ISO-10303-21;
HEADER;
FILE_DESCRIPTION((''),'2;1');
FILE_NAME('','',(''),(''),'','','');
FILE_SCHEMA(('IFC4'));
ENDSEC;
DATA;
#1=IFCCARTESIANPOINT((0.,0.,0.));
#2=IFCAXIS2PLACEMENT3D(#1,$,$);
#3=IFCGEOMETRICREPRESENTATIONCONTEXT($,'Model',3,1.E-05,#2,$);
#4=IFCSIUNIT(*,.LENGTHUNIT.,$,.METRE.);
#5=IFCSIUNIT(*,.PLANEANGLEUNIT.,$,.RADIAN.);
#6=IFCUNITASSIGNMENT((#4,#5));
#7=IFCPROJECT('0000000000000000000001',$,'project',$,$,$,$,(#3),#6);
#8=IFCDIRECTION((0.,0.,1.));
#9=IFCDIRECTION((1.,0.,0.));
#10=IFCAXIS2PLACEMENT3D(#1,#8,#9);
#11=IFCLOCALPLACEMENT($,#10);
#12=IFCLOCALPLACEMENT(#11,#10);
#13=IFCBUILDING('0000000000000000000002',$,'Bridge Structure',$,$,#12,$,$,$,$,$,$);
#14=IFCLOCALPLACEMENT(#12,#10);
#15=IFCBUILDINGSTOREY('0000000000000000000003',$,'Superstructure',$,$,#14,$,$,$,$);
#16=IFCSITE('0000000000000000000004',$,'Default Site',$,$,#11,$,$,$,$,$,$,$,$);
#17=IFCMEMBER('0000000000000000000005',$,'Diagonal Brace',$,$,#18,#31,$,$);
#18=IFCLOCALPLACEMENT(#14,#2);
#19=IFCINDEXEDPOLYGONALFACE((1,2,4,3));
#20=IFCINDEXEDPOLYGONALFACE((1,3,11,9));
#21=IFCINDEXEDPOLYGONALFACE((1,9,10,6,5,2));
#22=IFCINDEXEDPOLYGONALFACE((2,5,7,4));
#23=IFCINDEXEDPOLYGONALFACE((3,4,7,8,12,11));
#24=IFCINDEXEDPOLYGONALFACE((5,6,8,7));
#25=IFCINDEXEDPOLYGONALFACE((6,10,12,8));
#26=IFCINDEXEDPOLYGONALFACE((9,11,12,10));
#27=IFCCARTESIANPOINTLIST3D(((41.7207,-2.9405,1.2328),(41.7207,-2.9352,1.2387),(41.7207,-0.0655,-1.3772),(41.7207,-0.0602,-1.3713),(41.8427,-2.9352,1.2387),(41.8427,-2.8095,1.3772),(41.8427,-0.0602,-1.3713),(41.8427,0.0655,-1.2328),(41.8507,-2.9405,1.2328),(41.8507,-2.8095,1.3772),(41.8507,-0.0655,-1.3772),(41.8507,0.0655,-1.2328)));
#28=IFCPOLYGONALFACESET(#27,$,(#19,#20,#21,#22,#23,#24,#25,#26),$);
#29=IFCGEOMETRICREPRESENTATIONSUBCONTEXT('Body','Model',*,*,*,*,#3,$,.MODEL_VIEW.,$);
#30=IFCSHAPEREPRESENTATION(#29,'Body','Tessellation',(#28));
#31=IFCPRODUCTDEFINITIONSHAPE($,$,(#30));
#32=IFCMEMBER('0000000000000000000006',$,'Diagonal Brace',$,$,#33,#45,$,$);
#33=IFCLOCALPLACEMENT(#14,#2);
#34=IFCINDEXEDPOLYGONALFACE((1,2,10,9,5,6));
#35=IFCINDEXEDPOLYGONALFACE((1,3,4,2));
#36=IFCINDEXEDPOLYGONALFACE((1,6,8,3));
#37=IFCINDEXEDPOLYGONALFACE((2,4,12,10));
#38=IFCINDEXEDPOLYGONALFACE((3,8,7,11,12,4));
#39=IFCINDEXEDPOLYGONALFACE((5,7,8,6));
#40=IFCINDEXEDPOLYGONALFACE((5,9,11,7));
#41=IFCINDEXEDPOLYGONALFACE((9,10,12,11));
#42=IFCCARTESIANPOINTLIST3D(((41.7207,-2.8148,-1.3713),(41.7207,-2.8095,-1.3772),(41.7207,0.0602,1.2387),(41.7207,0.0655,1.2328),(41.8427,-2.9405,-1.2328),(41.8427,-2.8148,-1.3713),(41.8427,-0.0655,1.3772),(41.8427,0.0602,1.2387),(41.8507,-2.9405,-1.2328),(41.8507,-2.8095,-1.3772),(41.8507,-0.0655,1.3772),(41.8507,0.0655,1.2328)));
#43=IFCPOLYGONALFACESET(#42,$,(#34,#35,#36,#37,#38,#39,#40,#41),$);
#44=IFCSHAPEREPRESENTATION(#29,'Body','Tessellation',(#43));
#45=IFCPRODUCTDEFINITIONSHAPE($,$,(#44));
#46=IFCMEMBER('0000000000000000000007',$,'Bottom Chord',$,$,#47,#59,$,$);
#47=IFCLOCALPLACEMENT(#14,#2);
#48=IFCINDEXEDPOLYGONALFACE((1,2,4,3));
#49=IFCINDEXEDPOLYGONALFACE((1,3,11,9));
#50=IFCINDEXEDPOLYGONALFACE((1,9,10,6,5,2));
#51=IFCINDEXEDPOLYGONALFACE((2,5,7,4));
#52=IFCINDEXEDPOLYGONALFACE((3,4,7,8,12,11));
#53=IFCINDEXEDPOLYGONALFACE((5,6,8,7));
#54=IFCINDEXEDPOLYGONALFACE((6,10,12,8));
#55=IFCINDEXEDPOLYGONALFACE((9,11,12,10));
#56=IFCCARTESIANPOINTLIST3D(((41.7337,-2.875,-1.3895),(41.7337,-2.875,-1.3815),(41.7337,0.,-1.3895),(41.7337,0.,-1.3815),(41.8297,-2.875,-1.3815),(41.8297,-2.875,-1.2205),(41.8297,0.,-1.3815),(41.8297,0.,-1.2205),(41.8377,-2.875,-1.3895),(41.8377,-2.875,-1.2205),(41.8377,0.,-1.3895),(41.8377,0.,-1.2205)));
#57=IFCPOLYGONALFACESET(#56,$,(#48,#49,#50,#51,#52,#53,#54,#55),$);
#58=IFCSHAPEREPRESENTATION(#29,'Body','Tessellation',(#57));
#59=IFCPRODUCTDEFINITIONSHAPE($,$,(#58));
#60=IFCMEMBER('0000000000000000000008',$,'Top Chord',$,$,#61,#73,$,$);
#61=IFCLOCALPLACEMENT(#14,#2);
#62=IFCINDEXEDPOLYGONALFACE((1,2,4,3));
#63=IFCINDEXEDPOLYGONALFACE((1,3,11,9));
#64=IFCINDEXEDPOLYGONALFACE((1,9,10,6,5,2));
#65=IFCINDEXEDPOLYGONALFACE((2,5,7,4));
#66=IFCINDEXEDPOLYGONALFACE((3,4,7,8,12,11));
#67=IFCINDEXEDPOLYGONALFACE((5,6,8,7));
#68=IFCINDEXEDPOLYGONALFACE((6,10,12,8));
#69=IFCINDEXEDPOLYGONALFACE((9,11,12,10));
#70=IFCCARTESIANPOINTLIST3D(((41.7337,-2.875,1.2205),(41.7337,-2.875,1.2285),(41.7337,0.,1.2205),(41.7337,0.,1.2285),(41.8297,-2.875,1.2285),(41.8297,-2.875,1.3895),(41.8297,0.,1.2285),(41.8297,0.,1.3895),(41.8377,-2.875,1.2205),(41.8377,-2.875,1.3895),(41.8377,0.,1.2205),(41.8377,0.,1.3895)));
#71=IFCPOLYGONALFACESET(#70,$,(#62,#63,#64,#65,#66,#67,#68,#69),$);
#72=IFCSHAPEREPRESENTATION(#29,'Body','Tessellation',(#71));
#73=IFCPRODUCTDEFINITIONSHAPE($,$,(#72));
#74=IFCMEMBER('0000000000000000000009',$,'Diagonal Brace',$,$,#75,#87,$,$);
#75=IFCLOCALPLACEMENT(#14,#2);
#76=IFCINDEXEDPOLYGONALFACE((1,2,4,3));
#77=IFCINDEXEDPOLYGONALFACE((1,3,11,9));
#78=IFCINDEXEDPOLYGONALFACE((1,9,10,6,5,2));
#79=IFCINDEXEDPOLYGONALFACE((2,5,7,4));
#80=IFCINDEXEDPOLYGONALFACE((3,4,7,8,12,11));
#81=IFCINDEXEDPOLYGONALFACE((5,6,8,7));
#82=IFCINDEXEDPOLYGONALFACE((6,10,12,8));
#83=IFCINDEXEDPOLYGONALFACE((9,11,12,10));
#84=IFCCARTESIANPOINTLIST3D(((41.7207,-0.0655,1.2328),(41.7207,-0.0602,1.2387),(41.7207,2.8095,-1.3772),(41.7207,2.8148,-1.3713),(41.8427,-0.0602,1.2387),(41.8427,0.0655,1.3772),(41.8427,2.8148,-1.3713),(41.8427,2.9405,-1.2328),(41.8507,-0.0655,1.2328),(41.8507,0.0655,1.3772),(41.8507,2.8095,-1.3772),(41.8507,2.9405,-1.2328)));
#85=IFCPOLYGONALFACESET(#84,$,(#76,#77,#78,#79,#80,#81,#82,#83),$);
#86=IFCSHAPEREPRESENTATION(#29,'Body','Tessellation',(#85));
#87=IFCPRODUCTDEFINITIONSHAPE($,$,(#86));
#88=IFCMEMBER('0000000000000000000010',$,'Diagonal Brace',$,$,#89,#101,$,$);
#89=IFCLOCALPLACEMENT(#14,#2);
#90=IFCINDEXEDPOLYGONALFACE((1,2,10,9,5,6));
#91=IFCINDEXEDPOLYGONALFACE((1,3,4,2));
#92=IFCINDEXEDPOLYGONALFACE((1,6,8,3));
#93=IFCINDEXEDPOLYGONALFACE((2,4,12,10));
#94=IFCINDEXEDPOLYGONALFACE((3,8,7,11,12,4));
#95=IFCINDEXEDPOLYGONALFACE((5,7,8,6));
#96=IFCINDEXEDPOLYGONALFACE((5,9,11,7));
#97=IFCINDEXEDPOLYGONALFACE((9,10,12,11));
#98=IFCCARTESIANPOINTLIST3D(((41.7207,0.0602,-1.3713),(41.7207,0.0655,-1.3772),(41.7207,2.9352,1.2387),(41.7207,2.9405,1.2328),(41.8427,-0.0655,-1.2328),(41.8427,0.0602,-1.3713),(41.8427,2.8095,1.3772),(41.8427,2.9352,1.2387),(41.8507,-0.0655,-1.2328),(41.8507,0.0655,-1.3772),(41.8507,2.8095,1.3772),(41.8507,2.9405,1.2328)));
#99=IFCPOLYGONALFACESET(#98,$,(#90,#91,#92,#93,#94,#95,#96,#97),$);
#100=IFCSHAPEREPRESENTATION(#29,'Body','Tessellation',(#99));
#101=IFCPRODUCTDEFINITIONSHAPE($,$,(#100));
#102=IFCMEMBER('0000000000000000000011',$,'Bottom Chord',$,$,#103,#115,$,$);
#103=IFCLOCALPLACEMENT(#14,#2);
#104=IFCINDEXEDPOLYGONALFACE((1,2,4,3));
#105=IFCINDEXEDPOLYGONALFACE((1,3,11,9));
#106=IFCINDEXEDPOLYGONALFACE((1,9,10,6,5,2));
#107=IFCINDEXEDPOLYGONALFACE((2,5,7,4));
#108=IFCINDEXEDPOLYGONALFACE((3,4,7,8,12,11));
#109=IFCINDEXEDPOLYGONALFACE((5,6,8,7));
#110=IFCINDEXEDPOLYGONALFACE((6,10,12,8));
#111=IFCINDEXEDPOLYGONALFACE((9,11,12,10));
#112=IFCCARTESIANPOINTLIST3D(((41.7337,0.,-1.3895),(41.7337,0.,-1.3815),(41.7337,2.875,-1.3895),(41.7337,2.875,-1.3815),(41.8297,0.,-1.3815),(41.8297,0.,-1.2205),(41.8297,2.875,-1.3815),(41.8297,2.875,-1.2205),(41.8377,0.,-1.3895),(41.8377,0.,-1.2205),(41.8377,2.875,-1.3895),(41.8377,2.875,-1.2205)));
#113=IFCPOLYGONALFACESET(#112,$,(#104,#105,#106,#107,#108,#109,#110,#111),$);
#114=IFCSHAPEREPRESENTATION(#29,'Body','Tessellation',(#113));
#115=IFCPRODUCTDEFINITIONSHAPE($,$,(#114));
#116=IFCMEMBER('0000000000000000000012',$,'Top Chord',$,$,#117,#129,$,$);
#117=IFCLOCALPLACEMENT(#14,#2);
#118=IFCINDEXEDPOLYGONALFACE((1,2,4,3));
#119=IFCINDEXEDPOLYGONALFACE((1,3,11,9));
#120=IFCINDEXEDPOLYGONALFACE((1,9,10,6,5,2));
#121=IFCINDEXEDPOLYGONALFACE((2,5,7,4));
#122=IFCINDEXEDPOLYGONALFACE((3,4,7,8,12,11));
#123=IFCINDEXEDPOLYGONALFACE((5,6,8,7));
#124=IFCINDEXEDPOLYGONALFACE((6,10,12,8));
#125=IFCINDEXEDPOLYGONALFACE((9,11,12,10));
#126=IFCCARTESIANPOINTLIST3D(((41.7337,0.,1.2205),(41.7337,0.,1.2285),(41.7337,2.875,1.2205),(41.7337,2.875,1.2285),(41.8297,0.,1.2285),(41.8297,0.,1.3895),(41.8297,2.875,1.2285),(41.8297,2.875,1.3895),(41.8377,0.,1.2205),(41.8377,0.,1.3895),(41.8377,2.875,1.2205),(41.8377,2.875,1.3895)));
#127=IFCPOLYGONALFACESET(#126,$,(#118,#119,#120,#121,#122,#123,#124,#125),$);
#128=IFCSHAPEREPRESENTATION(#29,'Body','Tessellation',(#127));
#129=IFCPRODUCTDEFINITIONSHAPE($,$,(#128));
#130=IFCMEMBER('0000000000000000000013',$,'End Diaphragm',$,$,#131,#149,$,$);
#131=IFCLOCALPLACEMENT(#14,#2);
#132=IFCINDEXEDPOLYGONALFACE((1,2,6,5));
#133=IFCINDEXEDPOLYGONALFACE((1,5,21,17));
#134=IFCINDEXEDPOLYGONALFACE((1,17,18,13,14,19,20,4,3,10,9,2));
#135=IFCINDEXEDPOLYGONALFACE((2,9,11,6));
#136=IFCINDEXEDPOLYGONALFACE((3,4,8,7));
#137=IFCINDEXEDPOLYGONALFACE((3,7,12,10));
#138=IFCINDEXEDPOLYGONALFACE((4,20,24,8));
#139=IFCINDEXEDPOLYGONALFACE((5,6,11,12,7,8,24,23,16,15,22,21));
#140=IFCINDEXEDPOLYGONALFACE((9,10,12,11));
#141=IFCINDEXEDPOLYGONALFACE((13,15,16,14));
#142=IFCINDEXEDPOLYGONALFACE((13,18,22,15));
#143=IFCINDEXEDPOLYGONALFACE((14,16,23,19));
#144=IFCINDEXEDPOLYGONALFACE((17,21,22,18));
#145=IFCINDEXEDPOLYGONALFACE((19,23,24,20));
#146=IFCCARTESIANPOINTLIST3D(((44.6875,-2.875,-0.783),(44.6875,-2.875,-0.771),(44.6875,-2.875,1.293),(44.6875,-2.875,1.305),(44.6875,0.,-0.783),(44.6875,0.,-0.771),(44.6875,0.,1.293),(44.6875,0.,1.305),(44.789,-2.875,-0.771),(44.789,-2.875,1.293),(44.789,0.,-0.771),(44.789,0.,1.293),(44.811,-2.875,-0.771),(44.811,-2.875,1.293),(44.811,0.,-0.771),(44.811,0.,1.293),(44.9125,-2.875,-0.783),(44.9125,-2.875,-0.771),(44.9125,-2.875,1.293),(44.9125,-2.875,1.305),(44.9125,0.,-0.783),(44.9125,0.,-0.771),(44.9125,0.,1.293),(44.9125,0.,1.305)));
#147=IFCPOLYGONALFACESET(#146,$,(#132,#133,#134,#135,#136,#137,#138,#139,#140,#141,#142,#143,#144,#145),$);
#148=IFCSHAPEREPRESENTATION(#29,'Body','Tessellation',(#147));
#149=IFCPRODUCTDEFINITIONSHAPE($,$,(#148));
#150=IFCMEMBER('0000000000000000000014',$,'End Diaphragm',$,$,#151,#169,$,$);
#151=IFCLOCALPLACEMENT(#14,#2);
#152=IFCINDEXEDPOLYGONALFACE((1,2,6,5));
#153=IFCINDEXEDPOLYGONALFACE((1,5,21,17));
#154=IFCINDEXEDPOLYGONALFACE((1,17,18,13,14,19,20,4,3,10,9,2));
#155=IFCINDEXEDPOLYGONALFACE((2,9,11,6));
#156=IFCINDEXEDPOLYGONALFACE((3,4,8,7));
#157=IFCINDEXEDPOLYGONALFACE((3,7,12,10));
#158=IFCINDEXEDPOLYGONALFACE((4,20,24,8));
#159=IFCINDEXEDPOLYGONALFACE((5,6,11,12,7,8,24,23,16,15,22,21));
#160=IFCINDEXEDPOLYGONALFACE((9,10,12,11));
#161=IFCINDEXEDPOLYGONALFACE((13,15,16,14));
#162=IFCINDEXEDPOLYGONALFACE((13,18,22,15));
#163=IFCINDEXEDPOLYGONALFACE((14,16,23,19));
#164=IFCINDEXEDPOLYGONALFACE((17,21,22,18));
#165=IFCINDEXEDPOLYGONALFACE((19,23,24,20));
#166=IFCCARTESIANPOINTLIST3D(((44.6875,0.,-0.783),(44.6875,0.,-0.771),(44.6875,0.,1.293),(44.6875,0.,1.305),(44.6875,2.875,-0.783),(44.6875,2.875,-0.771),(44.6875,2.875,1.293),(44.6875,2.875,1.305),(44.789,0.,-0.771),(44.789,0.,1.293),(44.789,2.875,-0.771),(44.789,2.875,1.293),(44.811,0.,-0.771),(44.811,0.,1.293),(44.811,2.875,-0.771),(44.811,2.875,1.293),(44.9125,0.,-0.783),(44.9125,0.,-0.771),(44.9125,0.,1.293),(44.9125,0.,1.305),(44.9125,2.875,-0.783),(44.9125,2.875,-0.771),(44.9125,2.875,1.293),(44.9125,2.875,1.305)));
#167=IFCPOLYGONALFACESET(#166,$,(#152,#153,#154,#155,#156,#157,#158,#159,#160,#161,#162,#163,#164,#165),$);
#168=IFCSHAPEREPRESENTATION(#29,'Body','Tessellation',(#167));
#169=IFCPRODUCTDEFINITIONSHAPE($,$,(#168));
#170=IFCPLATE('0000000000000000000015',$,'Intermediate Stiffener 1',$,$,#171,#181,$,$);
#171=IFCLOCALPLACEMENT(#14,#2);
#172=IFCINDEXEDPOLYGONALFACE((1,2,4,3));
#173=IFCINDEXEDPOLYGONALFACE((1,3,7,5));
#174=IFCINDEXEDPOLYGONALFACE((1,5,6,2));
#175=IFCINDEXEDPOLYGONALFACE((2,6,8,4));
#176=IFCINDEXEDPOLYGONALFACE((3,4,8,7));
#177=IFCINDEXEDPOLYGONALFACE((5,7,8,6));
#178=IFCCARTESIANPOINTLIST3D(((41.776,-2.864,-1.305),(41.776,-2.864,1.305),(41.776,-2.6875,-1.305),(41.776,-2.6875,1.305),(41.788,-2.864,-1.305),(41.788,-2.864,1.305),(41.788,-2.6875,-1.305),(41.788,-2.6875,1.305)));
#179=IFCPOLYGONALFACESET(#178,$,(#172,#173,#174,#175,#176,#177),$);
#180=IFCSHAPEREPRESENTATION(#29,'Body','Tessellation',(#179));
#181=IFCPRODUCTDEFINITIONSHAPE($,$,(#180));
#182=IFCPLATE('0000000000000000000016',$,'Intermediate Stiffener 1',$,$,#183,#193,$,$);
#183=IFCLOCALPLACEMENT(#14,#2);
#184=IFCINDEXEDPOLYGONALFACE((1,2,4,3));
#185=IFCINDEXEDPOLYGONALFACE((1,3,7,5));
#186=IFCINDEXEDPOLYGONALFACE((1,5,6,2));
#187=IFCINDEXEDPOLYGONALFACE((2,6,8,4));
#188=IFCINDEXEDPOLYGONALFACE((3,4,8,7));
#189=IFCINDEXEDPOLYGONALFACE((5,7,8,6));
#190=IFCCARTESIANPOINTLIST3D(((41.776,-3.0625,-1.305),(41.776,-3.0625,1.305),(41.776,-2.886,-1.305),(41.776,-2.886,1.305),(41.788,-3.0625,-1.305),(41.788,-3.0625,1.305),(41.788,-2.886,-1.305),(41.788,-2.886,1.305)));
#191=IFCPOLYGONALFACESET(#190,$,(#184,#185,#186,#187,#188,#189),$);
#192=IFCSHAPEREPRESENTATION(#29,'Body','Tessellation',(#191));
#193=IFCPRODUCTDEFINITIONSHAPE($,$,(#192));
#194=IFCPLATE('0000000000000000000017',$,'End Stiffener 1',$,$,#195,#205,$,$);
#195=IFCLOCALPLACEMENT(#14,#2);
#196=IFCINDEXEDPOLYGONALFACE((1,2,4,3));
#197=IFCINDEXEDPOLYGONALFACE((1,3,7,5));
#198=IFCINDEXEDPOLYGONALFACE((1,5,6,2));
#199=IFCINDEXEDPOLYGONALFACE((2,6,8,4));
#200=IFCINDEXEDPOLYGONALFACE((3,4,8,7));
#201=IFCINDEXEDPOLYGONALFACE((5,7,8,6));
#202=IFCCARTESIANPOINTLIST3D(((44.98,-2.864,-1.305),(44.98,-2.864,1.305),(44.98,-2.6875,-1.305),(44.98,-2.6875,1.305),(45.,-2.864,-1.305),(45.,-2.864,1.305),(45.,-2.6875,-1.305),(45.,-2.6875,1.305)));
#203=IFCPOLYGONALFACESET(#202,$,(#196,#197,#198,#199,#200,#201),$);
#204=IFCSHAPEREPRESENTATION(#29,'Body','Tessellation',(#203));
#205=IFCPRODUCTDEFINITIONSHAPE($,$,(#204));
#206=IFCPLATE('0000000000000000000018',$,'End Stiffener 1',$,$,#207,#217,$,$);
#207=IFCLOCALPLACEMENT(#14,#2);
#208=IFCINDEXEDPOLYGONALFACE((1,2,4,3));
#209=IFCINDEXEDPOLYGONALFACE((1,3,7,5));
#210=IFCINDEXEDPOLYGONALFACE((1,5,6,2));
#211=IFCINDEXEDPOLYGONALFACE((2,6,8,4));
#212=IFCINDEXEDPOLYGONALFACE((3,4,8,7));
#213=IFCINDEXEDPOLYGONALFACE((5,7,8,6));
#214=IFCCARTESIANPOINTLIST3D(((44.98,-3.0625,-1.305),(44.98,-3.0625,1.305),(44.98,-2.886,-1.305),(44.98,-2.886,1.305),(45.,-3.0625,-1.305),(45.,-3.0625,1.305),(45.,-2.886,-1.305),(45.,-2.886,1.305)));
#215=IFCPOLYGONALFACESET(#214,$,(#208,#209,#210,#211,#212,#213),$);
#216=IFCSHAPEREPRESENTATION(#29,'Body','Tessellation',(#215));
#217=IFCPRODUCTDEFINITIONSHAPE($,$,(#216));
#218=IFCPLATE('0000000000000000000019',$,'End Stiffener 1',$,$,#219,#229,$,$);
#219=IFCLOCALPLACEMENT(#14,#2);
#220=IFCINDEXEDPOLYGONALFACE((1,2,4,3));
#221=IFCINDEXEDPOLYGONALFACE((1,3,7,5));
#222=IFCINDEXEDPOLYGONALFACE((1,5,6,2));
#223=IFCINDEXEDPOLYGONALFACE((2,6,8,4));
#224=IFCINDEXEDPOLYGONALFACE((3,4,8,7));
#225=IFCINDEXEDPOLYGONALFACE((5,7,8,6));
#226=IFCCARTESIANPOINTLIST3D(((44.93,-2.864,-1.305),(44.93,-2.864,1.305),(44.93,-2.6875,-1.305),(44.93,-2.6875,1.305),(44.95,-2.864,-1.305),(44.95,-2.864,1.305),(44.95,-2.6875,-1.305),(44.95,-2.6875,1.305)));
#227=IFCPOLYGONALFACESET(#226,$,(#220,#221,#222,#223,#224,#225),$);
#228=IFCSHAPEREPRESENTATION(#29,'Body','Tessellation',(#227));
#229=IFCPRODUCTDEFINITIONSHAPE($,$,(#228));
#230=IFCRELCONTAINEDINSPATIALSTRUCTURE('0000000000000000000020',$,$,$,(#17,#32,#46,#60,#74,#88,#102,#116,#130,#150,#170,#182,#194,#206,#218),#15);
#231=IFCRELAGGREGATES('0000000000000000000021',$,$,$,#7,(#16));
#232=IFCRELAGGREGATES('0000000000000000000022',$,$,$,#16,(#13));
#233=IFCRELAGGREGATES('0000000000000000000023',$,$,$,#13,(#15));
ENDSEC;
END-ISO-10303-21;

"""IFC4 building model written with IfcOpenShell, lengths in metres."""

from ifc_helpers import new_model, si_unit, frame, origin, origin_with_axes, origin_2d_with_axis, place, context, subcontext, project, spatial, rectangle, i_section, l_section, extrude, element, save


model = new_model("IFC4")

# Units and contexts
model_context = context("Model", 3, precision=1e-05, world=origin())
body_context = subcontext(model_context, "Body", "Model", "MODEL_VIEW")
ifc_project = project(units=[si_unit("LENGTHUNIT", "METRE"), si_unit("PLANEANGLEUNIT", "RADIAN")], contexts=[model_context])

# Site, building, storey
site_placement = place(None, origin_with_axes())
site = spatial("IfcSite", under=ifc_project, at=site_placement, Name="Default Site")
building_placement = place(site_placement, origin_with_axes())
building = spatial("IfcBuilding", under=site, at=building_placement, Name="Bridge Structure")
storey_placement = place(building_placement, origin_with_axes())
storey = spatial("IfcBuildingStorey", under=building, at=storey_placement, Name="Superstructure")

# Members
for number, where, z_axis, x_axis, name in (
    (1, (41.7857, -2.875, 1.305), (0.0, 0.740406, -0.67216), (-1.0, 0.0, 0.0), "Diagonal Brace"),
    (2, (41.7857, -2.875, -1.305), (0.0, 0.740406, 0.67216), (-1.0, 0.0, 0.0), "Diagonal Brace"),
):
    element("IfcMember", number, at=place(storey_placement, frame(where, z_axis=z_axis, x_axis=x_axis)), inside=storey, Name=name, context=body_context, shape_type="SweptSolid", body=[
        extrude(l_section(Depth=0.195, Width=0.13, Thickness=0.008, at=origin_2d_with_axis()), origin_with_axes(), (0.0, 0.0, 1.0), 3.883),
    ])
for number, where, z_axis, x_axis, name in (
    (3, (41.7857, -2.875, -1.305), (0.0, 1.0, 0.0), (-1.0, 0.0, 0.0), "Bottom Chord"),
    (4, (41.7857, -2.875, 1.305), (0.0, 1.0, 0.0), (-1.0, 0.0, 0.0), "Top Chord"),
):
    element("IfcMember", number, at=place(storey_placement, frame(where, z_axis=z_axis, x_axis=x_axis)), inside=storey, Name=name, context=body_context, shape_type="SweptSolid", body=[
        extrude(l_section(Depth=0.169, Width=0.104, Thickness=0.008, at=origin_2d_with_axis()), origin_with_axes(), (0.0, 0.0, 1.0), 2.875),
    ])
for number, where, z_axis, x_axis, name in (
    (5, (41.7857, 0.0, 1.305), (0.0, 0.740406, -0.67216), (-1.0, 0.0, 0.0), "Diagonal Brace"),
    (6, (41.7857, 0.0, -1.305), (0.0, 0.740406, 0.67216), (-1.0, 0.0, 0.0), "Diagonal Brace"),
):
    element("IfcMember", number, at=place(storey_placement, frame(where, z_axis=z_axis, x_axis=x_axis)), inside=storey, Name=name, context=body_context, shape_type="SweptSolid", body=[
        extrude(l_section(Depth=0.195, Width=0.13, Thickness=0.008, at=origin_2d_with_axis()), origin_with_axes(), (0.0, 0.0, 1.0), 3.883),
    ])
for number, where, z_axis, x_axis, name in (
    (7, (41.7857, 0.0, -1.305), (0.0, 1.0, 0.0), (-1.0, 0.0, 0.0), "Bottom Chord"),
    (8, (41.7857, 0.0, 1.305), (0.0, 1.0, 0.0), (-1.0, 0.0, 0.0), "Top Chord"),
):
    element("IfcMember", number, at=place(storey_placement, frame(where, z_axis=z_axis, x_axis=x_axis)), inside=storey, Name=name, context=body_context, shape_type="SweptSolid", body=[
        extrude(l_section(Depth=0.169, Width=0.104, Thickness=0.008, at=origin_2d_with_axis()), origin_with_axes(), (0.0, 0.0, 1.0), 2.875),
    ])
for number, where, z_axis, x_axis, name in (
    (9, (44.8, -2.875, 0.261), (0.0, 1.0, 0.0), (-1.0, 0.0, 0.0), "End Diaphragm"),
    (10, (44.8, 0.0, 0.261), (0.0, 1.0, 0.0), (-1.0, 0.0, 0.0), "End Diaphragm"),
):
    element("IfcMember", number, at=place(storey_placement, frame(where, z_axis=z_axis, x_axis=x_axis)), inside=storey, Name=name, context=body_context, shape_type="SweptSolid", body=[
        extrude(i_section(OverallWidth=0.225, OverallDepth=2.088, WebThickness=0.022, FlangeThickness=0.012, at=origin_2d_with_axis()), origin_with_axes(), (0.0, 0.0, 1.0), 2.875),
    ])

# Plates
for number, where, z_axis, x_axis, name in (
    (11, (41.782, -2.7757, -1.305), (0.0, 0.0, 1.0), (1.0, 0.0, 0.0), "Intermediate Stiffener 1"),
    (12, (41.782, -2.9743, -1.305), (0.0, 0.0, 1.0), (1.0, 0.0, 0.0), "Intermediate Stiffener 1"),
):
    element("IfcPlate", number, at=place(storey_placement, frame(where, z_axis=z_axis, x_axis=x_axis)), inside=storey, Name=name, context=body_context, shape_type="SweptSolid", body=[
        extrude(rectangle(XDim=0.012, YDim=0.1765, at=origin_2d_with_axis()), origin_with_axes(), (0.0, 0.0, 1.0), 2.61),
    ])
for number, where, z_axis, x_axis, name in (
    (13, (44.99, -2.7757, -1.305), (0.0, 0.0, 1.0), (1.0, 0.0, 0.0), "End Stiffener 1"),
    (14, (44.99, -2.9743, -1.305), (0.0, 0.0, 1.0), (1.0, 0.0, 0.0), "End Stiffener 1"),
    (15, (44.94, -2.7757, -1.305), (0.0, 0.0, 1.0), (1.0, 0.0, 0.0), "End Stiffener 1"),
):
    element("IfcPlate", number, at=place(storey_placement, frame(where, z_axis=z_axis, x_axis=x_axis)), inside=storey, Name=name, context=body_context, shape_type="SweptSolid", body=[
        extrude(rectangle(XDim=0.02, YDim=0.1765, at=origin_2d_with_axis()), origin_with_axes(), (0.0, 0.0, 1.0), 2.61),
    ])

save(model, "model.ifc")
